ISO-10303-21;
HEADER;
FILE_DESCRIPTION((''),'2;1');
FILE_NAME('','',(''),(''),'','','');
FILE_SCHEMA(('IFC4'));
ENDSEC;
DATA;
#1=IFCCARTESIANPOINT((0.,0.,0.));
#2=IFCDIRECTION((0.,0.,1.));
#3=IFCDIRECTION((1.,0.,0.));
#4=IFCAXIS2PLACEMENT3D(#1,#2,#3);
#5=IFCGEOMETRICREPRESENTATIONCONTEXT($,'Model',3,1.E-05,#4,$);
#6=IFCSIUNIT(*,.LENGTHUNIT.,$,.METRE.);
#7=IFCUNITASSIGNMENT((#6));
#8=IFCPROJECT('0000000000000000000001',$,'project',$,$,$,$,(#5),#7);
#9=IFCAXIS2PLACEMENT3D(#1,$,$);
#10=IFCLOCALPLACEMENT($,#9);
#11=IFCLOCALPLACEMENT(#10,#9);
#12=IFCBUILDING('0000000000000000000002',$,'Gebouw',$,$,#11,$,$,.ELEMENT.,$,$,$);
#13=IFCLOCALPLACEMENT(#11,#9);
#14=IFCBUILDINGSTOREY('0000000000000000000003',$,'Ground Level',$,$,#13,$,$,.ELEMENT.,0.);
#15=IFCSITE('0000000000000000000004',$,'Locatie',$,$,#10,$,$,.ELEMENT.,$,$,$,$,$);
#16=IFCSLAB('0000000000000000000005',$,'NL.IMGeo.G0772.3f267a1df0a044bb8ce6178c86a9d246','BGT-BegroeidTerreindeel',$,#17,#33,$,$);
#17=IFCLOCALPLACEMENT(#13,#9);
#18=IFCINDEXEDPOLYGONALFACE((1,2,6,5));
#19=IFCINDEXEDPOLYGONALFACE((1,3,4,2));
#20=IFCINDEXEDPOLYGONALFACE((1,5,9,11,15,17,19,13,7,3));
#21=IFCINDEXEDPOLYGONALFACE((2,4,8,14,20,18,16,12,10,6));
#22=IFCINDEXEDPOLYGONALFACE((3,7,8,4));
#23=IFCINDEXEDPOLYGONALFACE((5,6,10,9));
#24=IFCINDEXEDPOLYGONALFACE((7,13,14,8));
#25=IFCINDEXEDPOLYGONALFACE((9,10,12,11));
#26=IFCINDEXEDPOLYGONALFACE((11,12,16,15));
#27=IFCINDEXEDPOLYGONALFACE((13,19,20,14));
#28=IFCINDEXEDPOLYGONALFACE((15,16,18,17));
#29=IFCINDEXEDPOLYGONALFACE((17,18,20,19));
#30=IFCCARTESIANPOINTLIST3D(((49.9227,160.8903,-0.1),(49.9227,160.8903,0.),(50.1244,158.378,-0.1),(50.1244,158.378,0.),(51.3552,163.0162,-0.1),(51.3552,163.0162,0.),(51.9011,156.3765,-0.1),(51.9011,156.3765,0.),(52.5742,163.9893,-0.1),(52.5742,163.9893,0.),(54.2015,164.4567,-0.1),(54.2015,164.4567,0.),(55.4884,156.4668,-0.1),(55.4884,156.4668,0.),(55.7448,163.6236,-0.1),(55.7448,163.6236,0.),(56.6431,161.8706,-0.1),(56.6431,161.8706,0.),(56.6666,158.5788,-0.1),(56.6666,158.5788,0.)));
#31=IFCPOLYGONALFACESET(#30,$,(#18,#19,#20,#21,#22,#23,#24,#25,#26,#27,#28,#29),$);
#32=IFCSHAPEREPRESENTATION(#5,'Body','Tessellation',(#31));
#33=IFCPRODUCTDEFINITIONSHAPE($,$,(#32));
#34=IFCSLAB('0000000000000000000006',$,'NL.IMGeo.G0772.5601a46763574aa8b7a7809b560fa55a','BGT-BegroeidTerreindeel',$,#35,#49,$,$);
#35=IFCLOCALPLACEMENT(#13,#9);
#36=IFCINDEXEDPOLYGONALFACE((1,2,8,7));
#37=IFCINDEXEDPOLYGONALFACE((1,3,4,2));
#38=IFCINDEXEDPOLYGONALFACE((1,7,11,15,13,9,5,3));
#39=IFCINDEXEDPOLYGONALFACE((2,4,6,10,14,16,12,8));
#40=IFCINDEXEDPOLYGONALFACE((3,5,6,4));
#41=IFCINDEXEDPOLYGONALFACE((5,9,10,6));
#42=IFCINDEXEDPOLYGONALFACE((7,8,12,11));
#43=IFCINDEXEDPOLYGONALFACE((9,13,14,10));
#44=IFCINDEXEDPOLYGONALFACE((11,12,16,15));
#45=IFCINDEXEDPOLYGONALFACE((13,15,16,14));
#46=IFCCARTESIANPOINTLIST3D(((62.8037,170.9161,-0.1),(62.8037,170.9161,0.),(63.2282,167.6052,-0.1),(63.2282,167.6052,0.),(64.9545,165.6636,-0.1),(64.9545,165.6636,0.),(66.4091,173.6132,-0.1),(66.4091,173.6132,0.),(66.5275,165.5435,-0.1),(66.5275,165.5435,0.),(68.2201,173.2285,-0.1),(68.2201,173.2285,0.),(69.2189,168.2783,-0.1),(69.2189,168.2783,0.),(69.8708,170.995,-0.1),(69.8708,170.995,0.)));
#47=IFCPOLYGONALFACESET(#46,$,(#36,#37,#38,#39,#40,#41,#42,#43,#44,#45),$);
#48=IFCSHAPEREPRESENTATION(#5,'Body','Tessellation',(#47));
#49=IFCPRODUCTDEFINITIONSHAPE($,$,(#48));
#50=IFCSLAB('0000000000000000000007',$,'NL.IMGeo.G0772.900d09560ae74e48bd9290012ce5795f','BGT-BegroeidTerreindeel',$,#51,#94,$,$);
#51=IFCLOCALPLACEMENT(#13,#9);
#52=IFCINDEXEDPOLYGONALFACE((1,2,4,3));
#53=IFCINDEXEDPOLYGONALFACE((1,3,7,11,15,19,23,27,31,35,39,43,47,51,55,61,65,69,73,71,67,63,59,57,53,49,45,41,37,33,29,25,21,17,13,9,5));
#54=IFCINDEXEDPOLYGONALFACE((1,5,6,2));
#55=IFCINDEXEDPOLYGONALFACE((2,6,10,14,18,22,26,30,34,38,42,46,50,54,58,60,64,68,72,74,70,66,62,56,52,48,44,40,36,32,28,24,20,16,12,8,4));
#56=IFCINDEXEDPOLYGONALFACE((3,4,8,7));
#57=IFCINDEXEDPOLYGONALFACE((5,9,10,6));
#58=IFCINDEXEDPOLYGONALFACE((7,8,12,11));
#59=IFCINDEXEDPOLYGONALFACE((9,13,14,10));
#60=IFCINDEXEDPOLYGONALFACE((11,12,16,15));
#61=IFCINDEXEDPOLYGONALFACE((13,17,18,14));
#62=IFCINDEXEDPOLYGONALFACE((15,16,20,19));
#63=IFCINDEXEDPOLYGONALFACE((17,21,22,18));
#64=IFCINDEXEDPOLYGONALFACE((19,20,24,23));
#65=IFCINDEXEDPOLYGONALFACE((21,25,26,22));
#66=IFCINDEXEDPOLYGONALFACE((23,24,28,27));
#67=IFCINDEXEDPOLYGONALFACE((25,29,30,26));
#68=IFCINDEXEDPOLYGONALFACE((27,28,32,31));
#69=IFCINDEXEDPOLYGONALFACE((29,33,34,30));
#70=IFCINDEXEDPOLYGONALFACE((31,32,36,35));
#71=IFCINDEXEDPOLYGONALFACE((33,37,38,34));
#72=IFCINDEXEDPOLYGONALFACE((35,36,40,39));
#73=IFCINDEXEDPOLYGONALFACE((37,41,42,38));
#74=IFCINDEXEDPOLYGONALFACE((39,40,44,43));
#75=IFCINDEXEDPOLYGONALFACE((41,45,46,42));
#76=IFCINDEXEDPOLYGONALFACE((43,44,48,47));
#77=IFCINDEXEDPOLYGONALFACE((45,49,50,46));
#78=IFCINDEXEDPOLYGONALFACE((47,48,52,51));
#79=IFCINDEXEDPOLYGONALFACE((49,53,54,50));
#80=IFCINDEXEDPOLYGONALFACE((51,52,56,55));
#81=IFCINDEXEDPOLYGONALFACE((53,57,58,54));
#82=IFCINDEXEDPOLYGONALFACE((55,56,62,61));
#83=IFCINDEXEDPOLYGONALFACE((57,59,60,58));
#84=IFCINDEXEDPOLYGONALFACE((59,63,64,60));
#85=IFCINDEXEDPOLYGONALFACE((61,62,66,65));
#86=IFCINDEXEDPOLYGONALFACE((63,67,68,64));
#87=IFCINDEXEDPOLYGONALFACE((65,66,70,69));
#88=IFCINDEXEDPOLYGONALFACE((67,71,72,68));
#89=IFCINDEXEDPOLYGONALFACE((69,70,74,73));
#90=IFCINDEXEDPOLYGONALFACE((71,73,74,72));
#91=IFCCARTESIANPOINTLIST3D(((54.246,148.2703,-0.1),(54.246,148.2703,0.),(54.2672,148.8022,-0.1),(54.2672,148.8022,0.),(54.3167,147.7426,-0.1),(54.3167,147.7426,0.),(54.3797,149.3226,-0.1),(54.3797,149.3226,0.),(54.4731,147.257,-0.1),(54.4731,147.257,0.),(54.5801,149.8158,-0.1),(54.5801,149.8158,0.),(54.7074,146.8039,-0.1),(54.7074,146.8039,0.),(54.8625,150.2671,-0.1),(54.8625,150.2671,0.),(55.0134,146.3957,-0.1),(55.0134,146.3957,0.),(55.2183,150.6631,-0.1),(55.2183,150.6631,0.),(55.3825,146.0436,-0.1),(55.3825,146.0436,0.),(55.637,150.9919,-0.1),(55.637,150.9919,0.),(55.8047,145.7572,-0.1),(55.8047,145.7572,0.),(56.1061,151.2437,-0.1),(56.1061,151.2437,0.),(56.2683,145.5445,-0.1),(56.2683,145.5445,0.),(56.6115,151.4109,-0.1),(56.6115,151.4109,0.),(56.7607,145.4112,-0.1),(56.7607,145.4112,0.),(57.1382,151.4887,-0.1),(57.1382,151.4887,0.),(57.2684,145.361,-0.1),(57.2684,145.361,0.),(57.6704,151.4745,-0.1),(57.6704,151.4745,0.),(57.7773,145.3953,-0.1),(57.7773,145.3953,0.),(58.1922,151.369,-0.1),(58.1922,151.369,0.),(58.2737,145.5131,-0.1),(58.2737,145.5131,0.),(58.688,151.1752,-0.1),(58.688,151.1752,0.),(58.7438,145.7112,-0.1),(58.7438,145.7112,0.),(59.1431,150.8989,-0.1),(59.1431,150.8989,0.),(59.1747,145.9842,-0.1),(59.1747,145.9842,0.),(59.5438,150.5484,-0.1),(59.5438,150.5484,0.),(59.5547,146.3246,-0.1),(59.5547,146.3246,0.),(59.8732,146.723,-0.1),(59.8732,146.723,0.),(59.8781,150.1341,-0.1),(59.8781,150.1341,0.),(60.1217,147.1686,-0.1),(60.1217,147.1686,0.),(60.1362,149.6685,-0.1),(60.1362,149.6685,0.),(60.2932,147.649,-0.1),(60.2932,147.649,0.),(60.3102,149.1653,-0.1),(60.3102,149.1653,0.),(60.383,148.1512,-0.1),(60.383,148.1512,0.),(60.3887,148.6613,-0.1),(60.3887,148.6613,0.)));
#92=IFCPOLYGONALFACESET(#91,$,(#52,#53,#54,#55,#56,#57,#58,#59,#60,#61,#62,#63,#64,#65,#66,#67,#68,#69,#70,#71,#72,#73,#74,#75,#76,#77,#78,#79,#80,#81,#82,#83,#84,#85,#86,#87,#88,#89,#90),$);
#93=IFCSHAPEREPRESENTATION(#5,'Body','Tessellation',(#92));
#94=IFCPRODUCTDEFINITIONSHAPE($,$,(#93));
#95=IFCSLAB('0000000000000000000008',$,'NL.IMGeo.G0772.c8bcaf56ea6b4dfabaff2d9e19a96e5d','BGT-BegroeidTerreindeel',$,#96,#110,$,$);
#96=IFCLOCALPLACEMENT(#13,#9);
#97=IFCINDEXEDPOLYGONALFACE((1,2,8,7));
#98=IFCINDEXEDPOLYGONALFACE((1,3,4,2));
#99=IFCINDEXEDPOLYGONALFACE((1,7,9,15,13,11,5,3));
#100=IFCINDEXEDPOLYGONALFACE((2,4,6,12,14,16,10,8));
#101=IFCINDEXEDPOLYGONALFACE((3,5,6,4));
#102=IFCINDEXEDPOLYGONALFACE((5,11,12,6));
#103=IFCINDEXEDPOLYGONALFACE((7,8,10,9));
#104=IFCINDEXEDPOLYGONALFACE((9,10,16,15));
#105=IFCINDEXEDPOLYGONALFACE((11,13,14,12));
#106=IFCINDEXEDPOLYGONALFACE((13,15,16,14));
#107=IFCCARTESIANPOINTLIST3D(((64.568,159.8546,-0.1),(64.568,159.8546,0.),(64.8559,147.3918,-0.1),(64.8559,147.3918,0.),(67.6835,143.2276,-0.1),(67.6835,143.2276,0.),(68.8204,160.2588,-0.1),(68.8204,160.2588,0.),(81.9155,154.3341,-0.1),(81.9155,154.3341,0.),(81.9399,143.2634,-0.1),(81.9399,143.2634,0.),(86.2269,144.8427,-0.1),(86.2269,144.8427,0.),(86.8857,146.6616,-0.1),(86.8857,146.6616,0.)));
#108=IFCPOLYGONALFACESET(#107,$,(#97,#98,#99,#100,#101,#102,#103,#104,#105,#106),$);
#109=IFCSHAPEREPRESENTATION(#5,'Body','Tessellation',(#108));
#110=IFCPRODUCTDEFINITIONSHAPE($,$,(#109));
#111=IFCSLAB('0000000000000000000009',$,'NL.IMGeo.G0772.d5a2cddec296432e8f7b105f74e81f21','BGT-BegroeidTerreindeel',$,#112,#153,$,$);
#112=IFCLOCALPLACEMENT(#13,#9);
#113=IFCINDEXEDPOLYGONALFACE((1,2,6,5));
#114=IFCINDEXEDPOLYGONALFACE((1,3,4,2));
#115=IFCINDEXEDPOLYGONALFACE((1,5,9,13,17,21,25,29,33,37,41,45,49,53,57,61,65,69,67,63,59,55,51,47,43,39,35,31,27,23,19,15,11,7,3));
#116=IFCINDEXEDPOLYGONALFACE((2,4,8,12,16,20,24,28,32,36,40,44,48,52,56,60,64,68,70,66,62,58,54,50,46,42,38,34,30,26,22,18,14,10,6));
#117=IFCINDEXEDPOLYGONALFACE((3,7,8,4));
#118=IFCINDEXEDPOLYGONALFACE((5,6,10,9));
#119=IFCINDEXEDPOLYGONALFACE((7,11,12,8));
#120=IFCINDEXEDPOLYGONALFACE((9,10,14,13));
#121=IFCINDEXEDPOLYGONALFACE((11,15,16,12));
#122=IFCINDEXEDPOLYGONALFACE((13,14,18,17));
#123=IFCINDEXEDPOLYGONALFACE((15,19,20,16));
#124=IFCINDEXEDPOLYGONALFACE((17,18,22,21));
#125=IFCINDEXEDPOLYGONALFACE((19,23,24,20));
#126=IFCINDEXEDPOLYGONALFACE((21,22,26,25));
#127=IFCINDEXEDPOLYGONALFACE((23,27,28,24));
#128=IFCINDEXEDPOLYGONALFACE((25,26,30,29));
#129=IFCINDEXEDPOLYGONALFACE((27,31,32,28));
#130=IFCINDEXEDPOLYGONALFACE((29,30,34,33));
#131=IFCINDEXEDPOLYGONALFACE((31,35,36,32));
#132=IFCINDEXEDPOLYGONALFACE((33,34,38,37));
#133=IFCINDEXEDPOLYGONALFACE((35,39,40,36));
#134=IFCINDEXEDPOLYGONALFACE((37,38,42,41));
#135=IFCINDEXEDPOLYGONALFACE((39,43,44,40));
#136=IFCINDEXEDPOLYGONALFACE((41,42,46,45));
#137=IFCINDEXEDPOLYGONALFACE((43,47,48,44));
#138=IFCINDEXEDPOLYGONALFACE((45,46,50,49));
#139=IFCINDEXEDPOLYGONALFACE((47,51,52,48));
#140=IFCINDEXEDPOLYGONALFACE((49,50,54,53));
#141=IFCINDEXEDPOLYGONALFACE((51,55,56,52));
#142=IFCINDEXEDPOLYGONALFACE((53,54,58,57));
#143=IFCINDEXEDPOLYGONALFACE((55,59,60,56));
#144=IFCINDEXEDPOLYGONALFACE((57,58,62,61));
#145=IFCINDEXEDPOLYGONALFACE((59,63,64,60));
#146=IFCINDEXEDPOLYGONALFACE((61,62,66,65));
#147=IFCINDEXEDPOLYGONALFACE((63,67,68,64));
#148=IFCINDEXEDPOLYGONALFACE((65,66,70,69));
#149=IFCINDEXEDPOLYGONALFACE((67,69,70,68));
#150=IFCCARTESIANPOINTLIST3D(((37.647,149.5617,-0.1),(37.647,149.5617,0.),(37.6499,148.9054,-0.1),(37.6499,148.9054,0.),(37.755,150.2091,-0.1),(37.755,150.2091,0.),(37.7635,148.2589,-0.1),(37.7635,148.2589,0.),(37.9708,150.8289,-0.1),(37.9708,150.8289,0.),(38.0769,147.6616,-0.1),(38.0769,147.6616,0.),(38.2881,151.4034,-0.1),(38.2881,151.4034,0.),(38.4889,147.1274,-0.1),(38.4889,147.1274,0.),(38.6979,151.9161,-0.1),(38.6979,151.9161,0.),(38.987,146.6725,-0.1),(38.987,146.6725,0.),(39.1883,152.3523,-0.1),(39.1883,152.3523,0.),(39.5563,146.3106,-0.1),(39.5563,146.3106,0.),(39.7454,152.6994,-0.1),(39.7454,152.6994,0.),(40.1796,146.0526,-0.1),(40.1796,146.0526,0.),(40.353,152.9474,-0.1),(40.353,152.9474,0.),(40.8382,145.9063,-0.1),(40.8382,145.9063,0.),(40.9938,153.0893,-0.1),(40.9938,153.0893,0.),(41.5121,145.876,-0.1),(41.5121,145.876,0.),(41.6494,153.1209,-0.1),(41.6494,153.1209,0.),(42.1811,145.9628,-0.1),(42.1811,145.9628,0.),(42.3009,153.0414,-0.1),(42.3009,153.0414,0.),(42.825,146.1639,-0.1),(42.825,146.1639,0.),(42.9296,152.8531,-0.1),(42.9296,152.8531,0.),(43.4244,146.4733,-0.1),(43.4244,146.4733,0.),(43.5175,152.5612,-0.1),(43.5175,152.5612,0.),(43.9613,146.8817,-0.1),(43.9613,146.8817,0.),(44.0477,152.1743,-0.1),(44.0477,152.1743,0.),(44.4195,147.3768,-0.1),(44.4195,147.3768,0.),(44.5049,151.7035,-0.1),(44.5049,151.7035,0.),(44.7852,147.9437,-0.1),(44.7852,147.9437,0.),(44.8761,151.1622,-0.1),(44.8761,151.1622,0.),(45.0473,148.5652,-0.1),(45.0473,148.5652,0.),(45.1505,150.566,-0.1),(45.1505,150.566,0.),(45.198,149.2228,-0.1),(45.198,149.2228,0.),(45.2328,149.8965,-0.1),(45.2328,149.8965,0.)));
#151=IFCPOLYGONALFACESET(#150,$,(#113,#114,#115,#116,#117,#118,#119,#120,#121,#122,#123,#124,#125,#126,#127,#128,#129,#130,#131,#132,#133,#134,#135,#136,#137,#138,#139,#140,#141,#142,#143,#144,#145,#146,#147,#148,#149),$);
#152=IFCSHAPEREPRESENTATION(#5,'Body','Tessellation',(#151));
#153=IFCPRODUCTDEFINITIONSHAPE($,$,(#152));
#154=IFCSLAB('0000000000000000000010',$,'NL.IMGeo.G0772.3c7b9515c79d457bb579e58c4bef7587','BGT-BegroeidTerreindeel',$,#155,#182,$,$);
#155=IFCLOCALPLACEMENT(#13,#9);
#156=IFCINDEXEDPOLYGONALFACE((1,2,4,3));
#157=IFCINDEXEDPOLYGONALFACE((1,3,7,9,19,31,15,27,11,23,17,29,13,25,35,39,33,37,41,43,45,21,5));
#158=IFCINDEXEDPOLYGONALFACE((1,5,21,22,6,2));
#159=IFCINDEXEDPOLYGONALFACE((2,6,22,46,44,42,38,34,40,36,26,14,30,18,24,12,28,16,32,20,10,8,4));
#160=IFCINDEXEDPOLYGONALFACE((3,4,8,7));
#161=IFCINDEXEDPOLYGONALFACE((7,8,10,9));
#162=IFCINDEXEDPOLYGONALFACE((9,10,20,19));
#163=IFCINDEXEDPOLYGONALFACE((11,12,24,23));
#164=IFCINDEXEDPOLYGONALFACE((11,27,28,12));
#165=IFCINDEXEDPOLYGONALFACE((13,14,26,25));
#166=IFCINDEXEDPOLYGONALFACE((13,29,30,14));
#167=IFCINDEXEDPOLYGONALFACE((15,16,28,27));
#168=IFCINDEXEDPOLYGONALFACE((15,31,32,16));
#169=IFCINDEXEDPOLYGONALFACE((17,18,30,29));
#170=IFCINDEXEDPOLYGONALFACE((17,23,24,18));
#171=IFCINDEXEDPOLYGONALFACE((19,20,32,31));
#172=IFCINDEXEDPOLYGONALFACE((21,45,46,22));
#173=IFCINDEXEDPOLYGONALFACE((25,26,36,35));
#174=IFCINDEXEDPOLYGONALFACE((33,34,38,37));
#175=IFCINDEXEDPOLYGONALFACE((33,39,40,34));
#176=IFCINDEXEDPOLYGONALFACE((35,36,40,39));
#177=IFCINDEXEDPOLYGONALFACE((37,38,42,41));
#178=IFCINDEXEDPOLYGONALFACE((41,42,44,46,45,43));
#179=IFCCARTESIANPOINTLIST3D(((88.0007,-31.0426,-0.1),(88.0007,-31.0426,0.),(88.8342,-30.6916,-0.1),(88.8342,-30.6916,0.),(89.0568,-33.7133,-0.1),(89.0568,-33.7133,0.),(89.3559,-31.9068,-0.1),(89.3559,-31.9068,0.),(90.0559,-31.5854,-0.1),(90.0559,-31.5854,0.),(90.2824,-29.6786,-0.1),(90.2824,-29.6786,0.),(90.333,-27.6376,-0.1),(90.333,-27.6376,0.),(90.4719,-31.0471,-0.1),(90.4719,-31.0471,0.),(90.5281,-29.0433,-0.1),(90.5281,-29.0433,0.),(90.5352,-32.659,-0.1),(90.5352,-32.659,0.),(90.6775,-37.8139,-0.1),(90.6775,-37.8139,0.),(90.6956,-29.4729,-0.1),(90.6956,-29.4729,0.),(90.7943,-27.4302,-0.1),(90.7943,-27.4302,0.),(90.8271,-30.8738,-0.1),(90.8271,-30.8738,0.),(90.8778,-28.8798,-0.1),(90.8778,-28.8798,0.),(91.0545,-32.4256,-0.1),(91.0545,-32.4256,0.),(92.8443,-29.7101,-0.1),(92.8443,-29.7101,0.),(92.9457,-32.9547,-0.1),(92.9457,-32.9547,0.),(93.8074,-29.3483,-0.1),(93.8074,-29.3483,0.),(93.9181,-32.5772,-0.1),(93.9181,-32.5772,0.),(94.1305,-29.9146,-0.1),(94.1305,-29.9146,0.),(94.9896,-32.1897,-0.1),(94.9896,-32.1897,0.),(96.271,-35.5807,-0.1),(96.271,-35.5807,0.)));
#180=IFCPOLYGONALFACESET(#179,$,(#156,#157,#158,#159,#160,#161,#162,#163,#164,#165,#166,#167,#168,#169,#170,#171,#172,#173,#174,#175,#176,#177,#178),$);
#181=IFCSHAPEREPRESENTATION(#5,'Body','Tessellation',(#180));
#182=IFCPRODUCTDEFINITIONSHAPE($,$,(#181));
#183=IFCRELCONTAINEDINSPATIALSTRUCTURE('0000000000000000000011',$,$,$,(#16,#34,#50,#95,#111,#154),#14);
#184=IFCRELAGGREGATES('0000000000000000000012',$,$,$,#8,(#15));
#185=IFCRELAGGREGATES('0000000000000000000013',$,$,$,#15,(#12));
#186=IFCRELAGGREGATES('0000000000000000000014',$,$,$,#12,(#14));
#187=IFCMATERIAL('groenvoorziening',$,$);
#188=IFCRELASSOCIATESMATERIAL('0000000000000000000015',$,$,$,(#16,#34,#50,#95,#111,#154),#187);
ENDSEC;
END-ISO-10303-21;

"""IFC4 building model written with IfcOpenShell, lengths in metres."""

from ifc_helpers import new_model, si_unit, frame, origin, origin_with_axes, place, context, project, spatial, polyline, outline, extrude, material, element, save


model = new_model("IFC4")

# Units and contexts
model_context = context("Model", 3, precision=1e-05, world=origin_with_axes())
ifc_project = project(units=[si_unit("LENGTHUNIT", "METRE")], contexts=[model_context])

# Site, building, storey
site_placement = place(None, origin())
site = spatial("IfcSite", under=ifc_project, at=site_placement, Name="Locatie", CompositionType="ELEMENT")
building_placement = place(site_placement, origin())
building = spatial("IfcBuilding", under=site, at=building_placement, Name="Gebouw", CompositionType="ELEMENT")
storey_placement = place(building_placement, origin())
storey = spatial("IfcBuildingStorey", under=building, at=storey_placement, Name="Ground Level", CompositionType="ELEMENT", Elevation=0.0)

# Slabs
ifc_material = material(Name="groenvoorziening")
slab_1_placement = place(storey_placement, origin())
element("IfcSlab", 1, at=slab_1_placement, inside=storey, material=ifc_material, Name="NL.IMGeo.G0772.3f267a1df0a044bb8ce6178c86a9d246", Description="BGT-BegroeidTerreindeel", context=model_context, shape_type="SweptSolid", body=[
    extrude(outline(polyline([(54.2015, 164.4567), (55.7448, 163.6236), (56.6431, 161.8706), (56.6666, 158.5788), (55.4884, 156.4668), (51.9011, 156.3765), (50.1244, 158.378), (49.9227, 160.8903), (51.3552, 163.0162), (52.5742, 163.9893), (54.2015, 164.4567)])), frame((0.0, 0.0, -0.1), z_axis=(0.0, 0.0, 1.0), x_axis=(1.0, 0.0, 0.0)), (0.0, 0.0, 1.0), 0.1),
])
slab_2_placement = place(storey_placement, origin())
element("IfcSlab", 2, at=slab_2_placement, inside=storey, material=ifc_material, Name="NL.IMGeo.G0772.5601a46763574aa8b7a7809b560fa55a", Description="BGT-BegroeidTerreindeel", context=model_context, shape_type="SweptSolid", body=[
    extrude(outline(polyline([(69.8708, 170.995), (69.2189, 168.2783), (66.5275, 165.5435), (64.9545, 165.6636), (63.2282, 167.6052), (62.8037, 170.9161), (66.4091, 173.6132), (68.2201, 173.2285), (69.8708, 170.995)])), frame((0.0, 0.0, -0.1), z_axis=(0.0, 0.0, 1.0), x_axis=(1.0, 0.0, 0.0)), (0.0, 0.0, 1.0), 0.1),
])
slab_3_placement = place(storey_placement, origin())
element("IfcSlab", 3, at=slab_3_placement, inside=storey, material=ifc_material, Name="NL.IMGeo.G0772.900d09560ae74e48bd9290012ce5795f", Description="BGT-BegroeidTerreindeel", context=model_context, shape_type="SweptSolid", body=[
    extrude(outline(polyline([(54.246, 148.2703), (54.2672, 148.8022), (54.3797, 149.3226), (54.5801, 149.8158), (54.8625, 150.2671), (55.2183, 150.6631), (55.637, 150.9919), (56.1061, 151.2437), (56.6115, 151.4109), (57.1382, 151.4887), (57.6704, 151.4745), (58.1922, 151.369), (58.688, 151.1752), (59.1431, 150.8989), (59.5438, 150.5484), (59.8781, 150.1341), (60.1362, 149.6685), (60.3102, 149.1653), (60.3887, 148.6613), (60.383, 148.1512), (60.2932, 147.649), (60.1217, 147.1686), (59.8732, 146.723), (59.5547, 146.3246), (59.1747, 145.9842), (58.7438, 145.7112), (58.2737, 145.5131), (57.7773, 145.3953), (57.2684, 145.361), (56.7607, 145.4112), (56.2683, 145.5445), (55.8047, 145.7572), (55.3825, 146.0436), (55.0134, 146.3957), (54.7074, 146.8039), (54.4731, 147.257), (54.3167, 147.7426), (54.246, 148.2703)])), frame((0.0, 0.0, -0.1), z_axis=(0.0, 0.0, 1.0), x_axis=(1.0, 0.0, 0.0)), (0.0, 0.0, 1.0), 0.1),
])
slab_4_placement = place(storey_placement, origin())
element("IfcSlab", 4, at=slab_4_placement, inside=storey, material=ifc_material, Name="NL.IMGeo.G0772.c8bcaf56ea6b4dfabaff2d9e19a96e5d", Description="BGT-BegroeidTerreindeel", context=model_context, shape_type="SweptSolid", body=[
    extrude(outline(polyline([(86.8857, 146.6616), (86.2269, 144.8427), (81.9399, 143.2634), (67.6835, 143.2276), (64.8559, 147.3918), (64.568, 159.8546), (68.8204, 160.2588), (81.9155, 154.3341), (86.8857, 146.6616)])), frame((0.0, 0.0, -0.1), z_axis=(0.0, 0.0, 1.0), x_axis=(1.0, 0.0, 0.0)), (0.0, 0.0, 1.0), 0.1),
])
slab_5_placement = place(storey_placement, origin())
element("IfcSlab", 5, at=slab_5_placement, inside=storey, material=ifc_material, Name="NL.IMGeo.G0772.d5a2cddec296432e8f7b105f74e81f21", Description="BGT-BegroeidTerreindeel", context=model_context, shape_type="SweptSolid", body=[
    extrude(outline(polyline([(45.2328, 149.8965), (45.198, 149.2228), (45.0473, 148.5652), (44.7852, 147.9437), (44.4195, 147.3768), (43.9613, 146.8817), (43.4244, 146.4733), (42.825, 146.1639), (42.1811, 145.9628), (41.5121, 145.876), (40.8382, 145.9063), (40.1796, 146.0526), (39.5563, 146.3106), (38.987, 146.6725), (38.4889, 147.1274), (38.0769, 147.6616), (37.7635, 148.2589), (37.6499, 148.9054), (37.647, 149.5617), (37.755, 150.2091), (37.9708, 150.8289), (38.2881, 151.4034), (38.6979, 151.9161), (39.1883, 152.3523), (39.7454, 152.6994), (40.353, 152.9474), (40.9938, 153.0893), (41.6494, 153.1209), (42.3009, 153.0414), (42.9296, 152.8531), (43.5175, 152.5612), (44.0477, 152.1743), (44.5049, 151.7035), (44.8761, 151.1622), (45.1505, 150.566), (45.2328, 149.8965)])), frame((0.0, 0.0, -0.1), z_axis=(0.0, 0.0, 1.0), x_axis=(1.0, 0.0, 0.0)), (0.0, 0.0, 1.0), 0.1),
])
slab_6_placement = place(storey_placement, origin())
element("IfcSlab", 6, at=slab_6_placement, inside=storey, material=ifc_material, Name="NL.IMGeo.G0772.3c7b9515c79d457bb579e58c4bef7587", Description="BGT-BegroeidTerreindeel", context=model_context, shape_type="SweptSolid", body=[
    extrude(outline(polyline([(92.9457, -32.9547), (93.9181, -32.5772), (92.8443, -29.7101), (93.8074, -29.3483), (94.1305, -29.9146), (94.9896, -32.1897), (96.271, -35.5807), (90.6775, -37.8139), (89.0568, -33.7133), (88.0007, -31.0426), (88.8342, -30.6916), (89.3559, -31.9068), (90.0559, -31.5854), (90.5352, -32.659), (91.0545, -32.4256), (90.4719, -31.0471), (90.8271, -30.8738), (90.2824, -29.6786), (90.6956, -29.4729), (90.5281, -29.0433), (90.8778, -28.8798), (90.333, -27.6376), (90.7943, -27.4302), (92.9457, -32.9547)])), frame((0.0, 0.0, -0.1), z_axis=(0.0, 0.0, 1.0), x_axis=(1.0, 0.0, 0.0)), (0.0, 0.0, 1.0), 0.1),
])

save(model, "model.ifc")
